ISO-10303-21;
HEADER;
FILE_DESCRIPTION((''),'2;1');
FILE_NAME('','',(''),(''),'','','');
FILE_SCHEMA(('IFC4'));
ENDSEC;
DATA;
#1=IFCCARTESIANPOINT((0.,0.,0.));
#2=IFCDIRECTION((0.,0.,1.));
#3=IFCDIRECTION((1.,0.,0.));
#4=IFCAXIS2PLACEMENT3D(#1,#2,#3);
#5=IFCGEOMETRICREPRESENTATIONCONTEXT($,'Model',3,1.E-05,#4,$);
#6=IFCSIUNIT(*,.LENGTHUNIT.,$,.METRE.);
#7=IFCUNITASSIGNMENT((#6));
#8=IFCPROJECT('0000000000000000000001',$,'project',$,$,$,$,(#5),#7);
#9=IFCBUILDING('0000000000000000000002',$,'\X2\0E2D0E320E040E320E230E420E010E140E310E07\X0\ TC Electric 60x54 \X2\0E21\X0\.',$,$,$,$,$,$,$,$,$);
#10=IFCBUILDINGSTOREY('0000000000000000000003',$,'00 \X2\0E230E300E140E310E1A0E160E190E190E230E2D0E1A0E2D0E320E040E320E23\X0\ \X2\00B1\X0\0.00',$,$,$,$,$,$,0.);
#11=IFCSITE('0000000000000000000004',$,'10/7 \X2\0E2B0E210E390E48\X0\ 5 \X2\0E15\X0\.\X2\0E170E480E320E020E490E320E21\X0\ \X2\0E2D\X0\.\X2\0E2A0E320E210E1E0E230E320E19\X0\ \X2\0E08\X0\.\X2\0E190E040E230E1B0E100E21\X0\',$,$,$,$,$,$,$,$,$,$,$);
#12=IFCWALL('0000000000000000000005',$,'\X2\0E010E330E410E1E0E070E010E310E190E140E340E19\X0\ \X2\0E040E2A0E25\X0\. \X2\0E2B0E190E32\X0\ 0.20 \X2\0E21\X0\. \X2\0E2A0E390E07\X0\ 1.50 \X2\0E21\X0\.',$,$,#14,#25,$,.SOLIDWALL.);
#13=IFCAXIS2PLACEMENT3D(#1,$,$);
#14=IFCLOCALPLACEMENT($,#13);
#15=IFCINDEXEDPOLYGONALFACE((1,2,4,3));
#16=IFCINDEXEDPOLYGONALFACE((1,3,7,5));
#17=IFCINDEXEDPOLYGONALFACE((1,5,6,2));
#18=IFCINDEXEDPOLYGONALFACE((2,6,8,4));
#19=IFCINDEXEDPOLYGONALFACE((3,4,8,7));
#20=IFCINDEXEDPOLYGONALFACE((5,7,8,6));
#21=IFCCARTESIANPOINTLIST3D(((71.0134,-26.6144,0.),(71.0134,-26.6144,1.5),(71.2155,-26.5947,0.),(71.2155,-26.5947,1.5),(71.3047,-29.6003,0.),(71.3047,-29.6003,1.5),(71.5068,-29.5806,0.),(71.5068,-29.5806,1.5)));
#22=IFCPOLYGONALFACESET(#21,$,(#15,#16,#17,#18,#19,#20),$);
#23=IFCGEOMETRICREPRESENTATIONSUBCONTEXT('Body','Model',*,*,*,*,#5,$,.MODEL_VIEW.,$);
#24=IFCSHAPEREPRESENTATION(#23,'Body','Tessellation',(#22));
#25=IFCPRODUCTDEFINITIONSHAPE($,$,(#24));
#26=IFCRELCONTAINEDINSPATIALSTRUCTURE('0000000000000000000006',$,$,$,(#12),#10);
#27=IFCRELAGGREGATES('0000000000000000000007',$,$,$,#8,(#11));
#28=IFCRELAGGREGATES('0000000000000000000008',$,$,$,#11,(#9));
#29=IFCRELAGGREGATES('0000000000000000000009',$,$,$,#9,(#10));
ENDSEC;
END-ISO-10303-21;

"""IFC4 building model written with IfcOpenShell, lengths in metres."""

from ifc_helpers import new_model, si_unit, frame, origin, origin_with_axes, origin_2d, place, context, subcontext, project, spatial, rectangle, extrude, element, save


model = new_model("IFC4")

# Units and contexts
model_context = context("Model", 3, precision=1e-05, world=origin_with_axes())
body_context = subcontext(model_context, "Body", "Model", "MODEL_VIEW")
ifc_project = project(units=[si_unit("LENGTHUNIT", "METRE")], contexts=[model_context])

# Site, building, storey
site = spatial("IfcSite", under=ifc_project, Name="10/7 หมู่ 5 ต.ท่าข้าม อ.สามพราน จ.นครปฐม")
building = spatial("IfcBuilding", under=site, Name="อาคารโกดัง TC Electric 60x54 ม.")
storey = spatial("IfcBuildingStorey", under=building, Name="00 ระดับถนนรอบอาคาร ±0.00", Elevation=0.0)

# Wall
for number, where, z_axis, x_axis, name in (
    (1, (71.2601, -28.0975, 0.0), (0.0, 0.0, 1.0), (0.0971, -0.9953, 0.0), "กำแพงกันดิน คสล. หนา 0.20 ม. สูง 1.50 ม."),
):
    element("IfcWall", number, at=place(None, frame(where, z_axis=z_axis, x_axis=x_axis)), inside=storey, Name=name, PredefinedType="SOLIDWALL", context=body_context, shape_type="SweptSolid", body=[
        extrude(rectangle(XDim=3.0, YDim=0.203, at=origin_2d()), origin(), (0.0, 0.0, 1.0), 1.5),
    ])

save(model, "model.ifc")
